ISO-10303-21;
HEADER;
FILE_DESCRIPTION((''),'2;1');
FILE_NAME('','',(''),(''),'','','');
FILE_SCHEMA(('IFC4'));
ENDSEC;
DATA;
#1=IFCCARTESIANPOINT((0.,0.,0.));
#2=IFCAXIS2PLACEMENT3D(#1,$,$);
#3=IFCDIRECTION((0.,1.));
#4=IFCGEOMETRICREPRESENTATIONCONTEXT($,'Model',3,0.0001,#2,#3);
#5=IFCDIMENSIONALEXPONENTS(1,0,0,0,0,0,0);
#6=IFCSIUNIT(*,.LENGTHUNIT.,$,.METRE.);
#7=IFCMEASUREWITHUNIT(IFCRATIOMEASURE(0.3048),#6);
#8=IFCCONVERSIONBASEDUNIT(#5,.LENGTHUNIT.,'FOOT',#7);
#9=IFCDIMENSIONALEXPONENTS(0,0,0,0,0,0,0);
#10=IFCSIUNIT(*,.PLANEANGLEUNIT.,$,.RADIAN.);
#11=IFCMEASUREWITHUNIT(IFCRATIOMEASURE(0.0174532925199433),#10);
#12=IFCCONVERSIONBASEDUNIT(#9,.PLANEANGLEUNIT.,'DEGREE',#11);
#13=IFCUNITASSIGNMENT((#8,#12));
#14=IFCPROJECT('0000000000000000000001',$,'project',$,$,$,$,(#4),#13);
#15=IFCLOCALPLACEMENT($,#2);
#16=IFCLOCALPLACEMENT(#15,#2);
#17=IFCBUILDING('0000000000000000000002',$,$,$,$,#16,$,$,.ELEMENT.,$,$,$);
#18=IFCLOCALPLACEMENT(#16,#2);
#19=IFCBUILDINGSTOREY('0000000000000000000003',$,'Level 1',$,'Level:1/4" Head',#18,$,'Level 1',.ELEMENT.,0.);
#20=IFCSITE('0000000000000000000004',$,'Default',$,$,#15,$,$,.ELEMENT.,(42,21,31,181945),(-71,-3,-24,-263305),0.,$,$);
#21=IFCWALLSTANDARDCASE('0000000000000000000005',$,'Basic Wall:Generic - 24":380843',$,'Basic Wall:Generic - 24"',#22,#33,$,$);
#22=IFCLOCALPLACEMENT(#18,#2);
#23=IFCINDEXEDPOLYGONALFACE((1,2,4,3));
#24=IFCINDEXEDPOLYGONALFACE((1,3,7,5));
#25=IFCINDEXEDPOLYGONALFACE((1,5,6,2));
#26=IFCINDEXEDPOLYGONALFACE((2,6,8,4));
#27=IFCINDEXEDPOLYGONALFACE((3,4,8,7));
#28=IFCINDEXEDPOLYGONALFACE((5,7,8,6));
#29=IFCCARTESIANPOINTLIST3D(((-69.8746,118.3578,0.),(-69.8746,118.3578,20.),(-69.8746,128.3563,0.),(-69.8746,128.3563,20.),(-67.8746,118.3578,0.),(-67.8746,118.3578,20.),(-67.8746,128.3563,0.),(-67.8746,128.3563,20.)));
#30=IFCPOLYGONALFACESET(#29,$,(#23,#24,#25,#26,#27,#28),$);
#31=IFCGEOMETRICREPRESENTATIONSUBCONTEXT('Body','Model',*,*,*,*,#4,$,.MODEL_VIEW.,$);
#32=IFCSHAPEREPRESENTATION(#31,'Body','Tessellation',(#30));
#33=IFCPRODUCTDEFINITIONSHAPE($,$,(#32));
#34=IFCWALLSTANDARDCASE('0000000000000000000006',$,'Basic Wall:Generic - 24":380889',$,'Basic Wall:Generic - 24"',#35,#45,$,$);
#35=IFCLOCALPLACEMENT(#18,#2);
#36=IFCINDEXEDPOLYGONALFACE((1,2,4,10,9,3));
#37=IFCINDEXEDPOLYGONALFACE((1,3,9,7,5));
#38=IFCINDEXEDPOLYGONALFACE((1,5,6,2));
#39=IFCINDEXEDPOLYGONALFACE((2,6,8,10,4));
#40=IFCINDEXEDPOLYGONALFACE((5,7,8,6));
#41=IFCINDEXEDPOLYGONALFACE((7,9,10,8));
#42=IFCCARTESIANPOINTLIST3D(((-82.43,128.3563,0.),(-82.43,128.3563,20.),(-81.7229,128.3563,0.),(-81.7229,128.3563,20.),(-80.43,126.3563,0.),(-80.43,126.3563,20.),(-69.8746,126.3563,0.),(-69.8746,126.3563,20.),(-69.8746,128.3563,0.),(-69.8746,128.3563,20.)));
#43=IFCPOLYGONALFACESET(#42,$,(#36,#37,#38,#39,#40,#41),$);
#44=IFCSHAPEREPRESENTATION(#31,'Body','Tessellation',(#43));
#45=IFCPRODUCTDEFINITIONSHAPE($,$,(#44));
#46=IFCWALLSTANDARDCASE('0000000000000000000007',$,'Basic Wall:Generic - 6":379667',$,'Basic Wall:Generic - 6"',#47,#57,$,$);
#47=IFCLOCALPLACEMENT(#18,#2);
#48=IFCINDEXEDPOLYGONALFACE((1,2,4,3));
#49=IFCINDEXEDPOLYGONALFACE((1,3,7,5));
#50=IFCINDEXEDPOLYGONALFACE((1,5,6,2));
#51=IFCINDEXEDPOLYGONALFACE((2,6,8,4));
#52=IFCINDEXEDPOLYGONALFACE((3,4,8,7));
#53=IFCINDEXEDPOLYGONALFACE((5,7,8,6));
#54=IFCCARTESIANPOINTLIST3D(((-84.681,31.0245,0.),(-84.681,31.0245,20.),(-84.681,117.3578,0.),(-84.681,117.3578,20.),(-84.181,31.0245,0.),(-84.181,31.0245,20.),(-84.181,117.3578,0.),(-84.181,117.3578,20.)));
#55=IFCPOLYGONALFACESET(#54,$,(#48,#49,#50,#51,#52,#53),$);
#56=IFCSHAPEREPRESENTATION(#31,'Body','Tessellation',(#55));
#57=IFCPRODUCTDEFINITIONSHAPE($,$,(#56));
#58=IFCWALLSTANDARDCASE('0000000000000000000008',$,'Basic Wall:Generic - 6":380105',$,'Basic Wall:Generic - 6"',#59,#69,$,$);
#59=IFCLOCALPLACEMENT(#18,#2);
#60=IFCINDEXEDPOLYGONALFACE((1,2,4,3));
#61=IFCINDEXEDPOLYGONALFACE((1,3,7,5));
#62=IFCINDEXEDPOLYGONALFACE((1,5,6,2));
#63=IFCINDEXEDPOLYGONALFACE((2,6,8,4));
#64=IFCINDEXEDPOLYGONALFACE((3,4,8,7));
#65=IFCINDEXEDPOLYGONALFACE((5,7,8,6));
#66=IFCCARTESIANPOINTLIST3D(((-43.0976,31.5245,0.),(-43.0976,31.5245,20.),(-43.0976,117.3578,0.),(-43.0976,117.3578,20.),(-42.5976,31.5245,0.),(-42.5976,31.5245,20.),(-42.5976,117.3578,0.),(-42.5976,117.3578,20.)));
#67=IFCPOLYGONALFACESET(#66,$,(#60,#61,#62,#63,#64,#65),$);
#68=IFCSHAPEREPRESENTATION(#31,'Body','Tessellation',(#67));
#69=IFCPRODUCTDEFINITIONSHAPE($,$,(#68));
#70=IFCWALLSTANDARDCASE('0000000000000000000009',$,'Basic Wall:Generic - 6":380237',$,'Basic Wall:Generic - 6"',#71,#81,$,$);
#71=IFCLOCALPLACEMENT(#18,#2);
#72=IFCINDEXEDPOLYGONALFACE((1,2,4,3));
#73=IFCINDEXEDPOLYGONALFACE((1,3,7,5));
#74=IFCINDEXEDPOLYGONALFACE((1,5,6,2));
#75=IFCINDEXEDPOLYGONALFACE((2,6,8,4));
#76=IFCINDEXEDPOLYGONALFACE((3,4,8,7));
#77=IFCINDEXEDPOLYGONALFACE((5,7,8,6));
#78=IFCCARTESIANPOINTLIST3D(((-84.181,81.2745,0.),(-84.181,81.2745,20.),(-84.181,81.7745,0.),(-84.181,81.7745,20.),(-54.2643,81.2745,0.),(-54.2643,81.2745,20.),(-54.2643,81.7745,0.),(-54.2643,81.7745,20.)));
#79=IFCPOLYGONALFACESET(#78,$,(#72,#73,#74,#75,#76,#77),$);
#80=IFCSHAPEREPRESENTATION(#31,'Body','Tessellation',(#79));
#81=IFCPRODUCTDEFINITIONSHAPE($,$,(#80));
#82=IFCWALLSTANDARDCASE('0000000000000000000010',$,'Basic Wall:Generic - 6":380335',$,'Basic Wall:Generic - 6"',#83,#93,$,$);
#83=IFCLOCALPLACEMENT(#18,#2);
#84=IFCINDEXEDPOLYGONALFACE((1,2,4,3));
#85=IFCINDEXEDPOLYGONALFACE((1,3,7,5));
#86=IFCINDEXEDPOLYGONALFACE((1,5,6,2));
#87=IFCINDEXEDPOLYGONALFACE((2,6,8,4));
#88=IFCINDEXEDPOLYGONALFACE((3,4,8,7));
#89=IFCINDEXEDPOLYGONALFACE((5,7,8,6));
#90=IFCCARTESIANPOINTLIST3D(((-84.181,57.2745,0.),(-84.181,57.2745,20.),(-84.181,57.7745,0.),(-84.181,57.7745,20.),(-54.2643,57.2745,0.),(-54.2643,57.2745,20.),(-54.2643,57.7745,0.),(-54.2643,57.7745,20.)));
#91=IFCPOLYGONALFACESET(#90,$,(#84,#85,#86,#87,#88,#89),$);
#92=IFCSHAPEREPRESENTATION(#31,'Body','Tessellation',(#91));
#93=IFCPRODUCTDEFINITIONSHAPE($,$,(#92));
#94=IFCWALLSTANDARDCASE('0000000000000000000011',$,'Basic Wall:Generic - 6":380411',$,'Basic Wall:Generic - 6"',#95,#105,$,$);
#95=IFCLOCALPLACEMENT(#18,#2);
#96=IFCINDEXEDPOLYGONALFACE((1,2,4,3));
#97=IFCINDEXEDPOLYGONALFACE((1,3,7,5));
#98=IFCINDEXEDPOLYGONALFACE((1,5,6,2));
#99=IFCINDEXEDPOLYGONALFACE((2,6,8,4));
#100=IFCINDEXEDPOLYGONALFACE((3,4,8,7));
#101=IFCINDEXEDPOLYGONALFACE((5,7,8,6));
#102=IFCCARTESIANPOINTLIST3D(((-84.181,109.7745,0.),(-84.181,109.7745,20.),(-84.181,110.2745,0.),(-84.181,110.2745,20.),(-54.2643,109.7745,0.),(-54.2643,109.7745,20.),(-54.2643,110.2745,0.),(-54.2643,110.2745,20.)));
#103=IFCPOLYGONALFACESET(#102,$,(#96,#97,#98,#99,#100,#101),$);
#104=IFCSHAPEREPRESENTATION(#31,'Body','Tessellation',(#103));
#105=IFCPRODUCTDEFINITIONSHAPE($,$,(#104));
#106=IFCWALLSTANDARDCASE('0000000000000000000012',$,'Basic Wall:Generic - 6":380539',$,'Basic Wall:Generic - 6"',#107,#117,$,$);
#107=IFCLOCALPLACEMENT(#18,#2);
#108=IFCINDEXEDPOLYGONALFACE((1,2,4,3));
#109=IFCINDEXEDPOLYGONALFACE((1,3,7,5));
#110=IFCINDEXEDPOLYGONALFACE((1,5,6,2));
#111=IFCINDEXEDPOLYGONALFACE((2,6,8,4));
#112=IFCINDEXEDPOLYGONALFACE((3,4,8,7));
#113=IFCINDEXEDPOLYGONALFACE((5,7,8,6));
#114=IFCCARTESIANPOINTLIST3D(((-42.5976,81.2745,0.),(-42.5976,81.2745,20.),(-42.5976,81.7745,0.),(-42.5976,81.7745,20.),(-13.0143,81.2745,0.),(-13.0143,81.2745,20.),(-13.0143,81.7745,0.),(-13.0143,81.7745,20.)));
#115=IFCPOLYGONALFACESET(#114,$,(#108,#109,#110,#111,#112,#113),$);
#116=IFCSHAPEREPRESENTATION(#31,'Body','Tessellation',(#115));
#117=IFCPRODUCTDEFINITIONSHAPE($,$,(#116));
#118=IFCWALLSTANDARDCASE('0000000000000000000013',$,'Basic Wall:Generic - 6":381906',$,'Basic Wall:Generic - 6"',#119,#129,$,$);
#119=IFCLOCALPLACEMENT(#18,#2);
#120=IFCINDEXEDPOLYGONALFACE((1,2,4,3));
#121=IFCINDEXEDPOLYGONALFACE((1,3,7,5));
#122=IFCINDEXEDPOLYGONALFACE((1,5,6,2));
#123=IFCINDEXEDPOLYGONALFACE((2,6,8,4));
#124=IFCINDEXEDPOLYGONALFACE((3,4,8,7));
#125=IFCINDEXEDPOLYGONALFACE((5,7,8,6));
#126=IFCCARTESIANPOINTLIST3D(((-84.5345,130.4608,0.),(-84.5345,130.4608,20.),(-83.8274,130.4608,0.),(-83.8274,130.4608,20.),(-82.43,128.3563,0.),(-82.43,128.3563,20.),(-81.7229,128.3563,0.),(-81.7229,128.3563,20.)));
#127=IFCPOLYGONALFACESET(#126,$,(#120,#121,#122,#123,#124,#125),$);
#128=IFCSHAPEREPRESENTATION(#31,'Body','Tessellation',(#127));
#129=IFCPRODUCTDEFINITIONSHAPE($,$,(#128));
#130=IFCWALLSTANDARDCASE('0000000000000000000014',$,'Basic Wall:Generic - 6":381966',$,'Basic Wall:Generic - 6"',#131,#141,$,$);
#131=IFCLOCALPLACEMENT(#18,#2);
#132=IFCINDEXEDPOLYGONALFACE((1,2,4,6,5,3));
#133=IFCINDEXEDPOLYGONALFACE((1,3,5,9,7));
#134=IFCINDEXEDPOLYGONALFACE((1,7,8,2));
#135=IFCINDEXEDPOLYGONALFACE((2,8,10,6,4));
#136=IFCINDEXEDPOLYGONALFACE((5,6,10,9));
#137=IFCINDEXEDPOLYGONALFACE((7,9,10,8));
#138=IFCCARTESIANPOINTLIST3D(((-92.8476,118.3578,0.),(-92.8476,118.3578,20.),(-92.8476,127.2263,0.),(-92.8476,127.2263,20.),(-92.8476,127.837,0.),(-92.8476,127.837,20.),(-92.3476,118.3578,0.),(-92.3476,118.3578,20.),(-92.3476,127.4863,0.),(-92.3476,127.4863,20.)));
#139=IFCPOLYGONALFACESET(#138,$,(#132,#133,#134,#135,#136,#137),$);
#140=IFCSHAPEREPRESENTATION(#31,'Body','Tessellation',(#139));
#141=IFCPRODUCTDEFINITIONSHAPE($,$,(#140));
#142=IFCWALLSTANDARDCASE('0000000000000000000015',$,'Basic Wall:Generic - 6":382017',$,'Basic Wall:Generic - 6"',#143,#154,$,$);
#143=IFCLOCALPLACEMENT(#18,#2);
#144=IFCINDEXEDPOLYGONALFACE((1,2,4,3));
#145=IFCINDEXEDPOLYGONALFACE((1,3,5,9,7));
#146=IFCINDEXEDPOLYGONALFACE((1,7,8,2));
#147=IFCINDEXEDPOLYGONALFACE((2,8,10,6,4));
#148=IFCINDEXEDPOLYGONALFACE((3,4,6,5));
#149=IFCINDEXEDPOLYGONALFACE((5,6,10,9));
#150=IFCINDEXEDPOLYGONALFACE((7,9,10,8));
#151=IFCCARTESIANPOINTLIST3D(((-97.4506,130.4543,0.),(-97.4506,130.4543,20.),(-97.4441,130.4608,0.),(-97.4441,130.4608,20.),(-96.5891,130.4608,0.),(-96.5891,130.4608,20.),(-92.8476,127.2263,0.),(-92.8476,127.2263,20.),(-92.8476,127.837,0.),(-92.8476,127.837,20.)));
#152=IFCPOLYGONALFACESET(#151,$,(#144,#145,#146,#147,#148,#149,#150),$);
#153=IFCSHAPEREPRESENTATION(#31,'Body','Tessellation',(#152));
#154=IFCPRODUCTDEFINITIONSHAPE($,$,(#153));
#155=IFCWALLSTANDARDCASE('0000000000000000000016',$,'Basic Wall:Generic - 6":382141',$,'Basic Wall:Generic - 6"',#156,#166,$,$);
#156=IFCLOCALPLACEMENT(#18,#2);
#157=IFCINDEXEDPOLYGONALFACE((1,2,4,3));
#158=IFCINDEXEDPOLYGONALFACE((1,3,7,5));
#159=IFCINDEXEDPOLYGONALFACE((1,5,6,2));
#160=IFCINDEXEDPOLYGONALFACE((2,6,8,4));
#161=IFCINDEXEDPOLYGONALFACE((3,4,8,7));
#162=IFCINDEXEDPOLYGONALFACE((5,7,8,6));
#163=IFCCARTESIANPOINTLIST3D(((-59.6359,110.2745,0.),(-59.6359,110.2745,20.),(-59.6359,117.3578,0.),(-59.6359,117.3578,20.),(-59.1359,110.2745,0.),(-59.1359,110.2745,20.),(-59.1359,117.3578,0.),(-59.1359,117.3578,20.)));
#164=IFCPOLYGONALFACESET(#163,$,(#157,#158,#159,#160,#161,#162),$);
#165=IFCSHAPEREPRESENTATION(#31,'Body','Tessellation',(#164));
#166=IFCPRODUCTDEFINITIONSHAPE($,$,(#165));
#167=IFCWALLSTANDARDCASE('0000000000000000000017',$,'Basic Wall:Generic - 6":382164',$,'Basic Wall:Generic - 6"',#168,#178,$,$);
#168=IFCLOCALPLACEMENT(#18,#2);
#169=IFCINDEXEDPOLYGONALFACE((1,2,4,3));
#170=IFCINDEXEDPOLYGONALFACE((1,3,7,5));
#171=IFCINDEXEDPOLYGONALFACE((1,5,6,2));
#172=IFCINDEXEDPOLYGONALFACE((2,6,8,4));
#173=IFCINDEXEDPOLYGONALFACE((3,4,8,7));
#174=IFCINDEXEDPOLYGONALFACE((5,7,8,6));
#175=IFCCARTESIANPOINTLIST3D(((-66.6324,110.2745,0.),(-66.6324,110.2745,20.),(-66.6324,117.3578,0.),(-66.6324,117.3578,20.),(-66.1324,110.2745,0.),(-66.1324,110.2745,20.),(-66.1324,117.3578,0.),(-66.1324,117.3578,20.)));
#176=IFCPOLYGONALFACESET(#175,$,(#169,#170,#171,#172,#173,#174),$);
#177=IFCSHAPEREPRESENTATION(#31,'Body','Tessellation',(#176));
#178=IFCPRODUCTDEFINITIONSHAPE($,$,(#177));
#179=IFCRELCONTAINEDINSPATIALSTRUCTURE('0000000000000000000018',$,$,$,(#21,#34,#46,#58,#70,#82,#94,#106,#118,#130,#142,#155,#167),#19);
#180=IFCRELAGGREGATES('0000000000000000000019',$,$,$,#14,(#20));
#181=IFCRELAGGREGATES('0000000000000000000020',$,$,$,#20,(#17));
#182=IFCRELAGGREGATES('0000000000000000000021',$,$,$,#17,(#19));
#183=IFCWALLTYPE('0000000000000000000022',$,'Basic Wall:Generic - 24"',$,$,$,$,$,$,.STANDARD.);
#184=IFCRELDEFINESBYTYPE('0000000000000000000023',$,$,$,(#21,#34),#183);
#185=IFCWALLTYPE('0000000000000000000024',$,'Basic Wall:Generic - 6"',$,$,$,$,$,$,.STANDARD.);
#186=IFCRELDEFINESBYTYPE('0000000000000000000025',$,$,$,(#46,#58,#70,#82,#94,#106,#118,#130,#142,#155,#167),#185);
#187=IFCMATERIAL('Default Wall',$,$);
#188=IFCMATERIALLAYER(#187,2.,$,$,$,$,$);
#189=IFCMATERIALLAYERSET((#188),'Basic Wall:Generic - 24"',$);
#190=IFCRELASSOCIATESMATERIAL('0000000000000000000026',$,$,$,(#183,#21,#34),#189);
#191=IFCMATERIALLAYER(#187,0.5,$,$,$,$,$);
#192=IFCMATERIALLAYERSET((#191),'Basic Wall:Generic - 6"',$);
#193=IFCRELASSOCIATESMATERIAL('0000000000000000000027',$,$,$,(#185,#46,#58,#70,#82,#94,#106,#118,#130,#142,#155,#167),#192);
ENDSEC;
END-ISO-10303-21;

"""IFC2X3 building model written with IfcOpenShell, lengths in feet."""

from ifc_helpers import new_model, entity, si_unit, converted_unit, direction, frame, frame_2d, origin, place, context, subcontext, project, spatial, polyline, rectangle, outline, extrude, material, layer, layer_set, layer_usage, type_object, element, save


model = new_model("IFC2X3")

# Units and contexts
model_context = context("Model", 3, precision=0.0001, world=origin(), true_north=direction((0.0, 1.0)))
body_context = subcontext(model_context, "Body", "Model", "MODEL_VIEW")
ifc_project = project(units=[converted_unit("LENGTHUNIT", "FOOT", entity("IfcRatioMeasure", 0.3048), si_unit("LENGTHUNIT", "METRE"), dimensions=[1, 0, 0, 0, 0, 0, 0]), converted_unit("PLANEANGLEUNIT", "DEGREE", entity("IfcRatioMeasure", 0.0174532925199433), si_unit("PLANEANGLEUNIT", "RADIAN"), dimensions=[0, 0, 0, 0, 0, 0, 0])], contexts=[model_context])

# Site, building, storey
site_placement = place(None, origin())
site = spatial("IfcSite", under=ifc_project, at=site_placement, Name="Default", CompositionType="ELEMENT", RefLatitude=(42, 21, 31, 181945), RefLongitude=(-71, -3, -24, -263305), RefElevation=0.0)
building_placement = place(site_placement, origin())
building = spatial("IfcBuilding", under=site, at=building_placement, CompositionType="ELEMENT")
storey_placement = place(building_placement, origin())
storey = spatial("IfcBuildingStorey", under=building, at=storey_placement, Name="Level 1", ObjectType="Level:1/4\" Head", LongName="Level 1", CompositionType="ELEMENT", Elevation=0.0)

# Walls
ifc_material = material(Name="Default Wall")
ifc_layer_1 = layer(ifc_material, 2.0)
ifc_layer_set_1 = layer_set([ifc_layer_1], Name="Basic Wall:Generic - 24\"")
ifc_layer_usage_1 = layer_usage(ifc_layer_set_1, "AXIS2", "NEGATIVE", 1.0)
wall_type_1 = type_object("IfcWallType", Name="Basic Wall:Generic - 24\"", PredefinedType="STANDARD", material=ifc_layer_set_1)
wall_1_placement = place(storey_placement, frame((-68.8746, 118.3578, 0.0), z_axis=(0.0, 0.0, 1.0), x_axis=(0.0, 1.0, 0.0)))
element("IfcWallStandardCase", 1, at=wall_1_placement, inside=storey, type_object=wall_type_1, material=ifc_layer_usage_1, Name="Basic Wall:Generic - 24\":380843", ObjectType="Basic Wall:Generic - 24\"", context=body_context, shape_type="SweptSolid", body=[
    extrude(rectangle(XDim=9.9985, YDim=2.0, at=frame_2d((4.9992, 0.0), x_axis=(-1.0, 0.0))), origin(), (0.0, 0.0, 1.0), 20.0),
])
ifc_layer_usage_2 = layer_usage(ifc_layer_set_1, "AXIS2", "NEGATIVE", 1.0)
wall_2_placement = place(storey_placement, frame((-69.8746, 127.3563, 0.0), z_axis=(0.0, 0.0, 1.0), x_axis=(-1.0, 0.0, 0.0)))
element("IfcWallStandardCase", 2, at=wall_2_placement, inside=storey, type_object=wall_type_1, material=ifc_layer_usage_2, Name="Basic Wall:Generic - 24\":380889", ObjectType="Basic Wall:Generic - 24\"", context=body_context, shape_type="SweptSolid", body=[
    extrude(outline(polyline([(12.5555, -1.0), (10.5555, 1.0), (0.0, 1.0), (0.0, -1.0), (11.8484, -1.0), (12.5555, -1.0)])), origin(), (0.0, 0.0, 1.0), 20.0),
])
ifc_layer_2 = layer(ifc_material, 0.5)
ifc_layer_set_2 = layer_set([ifc_layer_2], Name="Basic Wall:Generic - 6\"")
ifc_layer_usage_3 = layer_usage(ifc_layer_set_2, "AXIS2", "NEGATIVE", 0.25)
wall_type_2 = type_object("IfcWallType", Name="Basic Wall:Generic - 6\"", PredefinedType="STANDARD", material=ifc_layer_set_2)
wall_3_placement = place(storey_placement, frame((-84.431, 117.3578, 0.0), z_axis=(0.0, 0.0, 1.0), x_axis=(0.0, -1.0, 0.0)))
element("IfcWallStandardCase", 3, at=wall_3_placement, inside=storey, type_object=wall_type_2, material=ifc_layer_usage_3, Name="Basic Wall:Generic - 6\":379667", ObjectType="Basic Wall:Generic - 6\"", context=body_context, shape_type="SweptSolid", body=[
    extrude(rectangle(XDim=86.3333, YDim=0.5, at=frame_2d((43.1667, 0.0), x_axis=(-1.0, 0.0))), origin(), (0.0, 0.0, 1.0), 20.0),
])
ifc_layer_usage_4 = layer_usage(ifc_layer_set_2, "AXIS2", "NEGATIVE", 0.25)
wall_4_placement = place(storey_placement, frame((-42.8476, 117.3578, 0.0), z_axis=(0.0, 0.0, 1.0), x_axis=(0.0, -1.0, 0.0)))
element("IfcWallStandardCase", 4, at=wall_4_placement, inside=storey, type_object=wall_type_2, material=ifc_layer_usage_4, Name="Basic Wall:Generic - 6\":380105", ObjectType="Basic Wall:Generic - 6\"", context=body_context, shape_type="SweptSolid", body=[
    extrude(rectangle(XDim=85.8333, YDim=0.5, at=frame_2d((42.9167, 0.0), x_axis=(-1.0, 0.0))), origin(), (0.0, 0.0, 1.0), 20.0),
])
ifc_layer_usage_5 = layer_usage(ifc_layer_set_2, "AXIS2", "NEGATIVE", 0.25)
wall_5_placement = place(storey_placement, frame((-84.181, 81.5245, 0.0)))
element("IfcWallStandardCase", 5, at=wall_5_placement, inside=storey, type_object=wall_type_2, material=ifc_layer_usage_5, Name="Basic Wall:Generic - 6\":380237", ObjectType="Basic Wall:Generic - 6\"", context=body_context, shape_type="SweptSolid", body=[
    extrude(rectangle(XDim=29.9167, YDim=0.5, at=frame_2d((14.9583, 0.0), x_axis=(-1.0, 0.0))), origin(), (0.0, 0.0, 1.0), 20.0),
])
ifc_layer_usage_6 = layer_usage(ifc_layer_set_2, "AXIS2", "NEGATIVE", 0.25)
wall_6_placement = place(storey_placement, frame((-84.181, 57.5245, 0.0)))
element("IfcWallStandardCase", 6, at=wall_6_placement, inside=storey, type_object=wall_type_2, material=ifc_layer_usage_6, Name="Basic Wall:Generic - 6\":380335", ObjectType="Basic Wall:Generic - 6\"", context=body_context, shape_type="SweptSolid", body=[
    extrude(rectangle(XDim=29.9167, YDim=0.5, at=frame_2d((14.9583, 0.0), x_axis=(-1.0, 0.0))), origin(), (0.0, 0.0, 1.0), 20.0),
])
ifc_layer_usage_7 = layer_usage(ifc_layer_set_2, "AXIS2", "NEGATIVE", 0.25)
wall_7_placement = place(storey_placement, frame((-54.2643, 110.0245, 0.0), z_axis=(0.0, 0.0, 1.0), x_axis=(-1.0, 0.0, 0.0)))
element("IfcWallStandardCase", 7, at=wall_7_placement, inside=storey, type_object=wall_type_2, material=ifc_layer_usage_7, Name="Basic Wall:Generic - 6\":380411", ObjectType="Basic Wall:Generic - 6\"", context=body_context, shape_type="SweptSolid", body=[
    extrude(rectangle(XDim=29.9167, YDim=0.5, at=frame_2d((14.9583, 0.0), x_axis=(-1.0, 0.0))), origin(), (0.0, 0.0, 1.0), 20.0),
])
ifc_layer_usage_8 = layer_usage(ifc_layer_set_2, "AXIS2", "NEGATIVE", 0.25)
wall_8_placement = place(storey_placement, frame((-42.5976, 81.5245, 0.0)))
element("IfcWallStandardCase", 8, at=wall_8_placement, inside=storey, type_object=wall_type_2, material=ifc_layer_usage_8, Name="Basic Wall:Generic - 6\":380539", ObjectType="Basic Wall:Generic - 6\"", context=body_context, shape_type="SweptSolid", body=[
    extrude(rectangle(XDim=29.5833, YDim=0.5, at=frame_2d((14.7917, 0.0), x_axis=(-1.0, 0.0))), origin(), (0.0, 0.0, 1.0), 20.0),
])
ifc_layer_usage_9 = layer_usage(ifc_layer_set_2, "AXIS2", "NEGATIVE", 0.25)
wall_9_placement = place(storey_placement, frame((-84.3578, 130.6376, 0.0), z_axis=(0.0, 0.0, 1.0), x_axis=(0.707107, -0.707107, 0.0)))
element("IfcWallStandardCase", 9, at=wall_9_placement, inside=storey, type_object=wall_type_2, material=ifc_layer_usage_9, Name="Basic Wall:Generic - 6\":381906", ObjectType="Basic Wall:Generic - 6\"", context=body_context, shape_type="SweptSolid", body=[
    extrude(outline(polyline([(2.9762, -0.25), (3.4762, 0.25), (0.5, 0.25), (0.0, -0.25), (2.9762, -0.25)])), origin(), (0.0, 0.0, 1.0), 20.0),
])
ifc_layer_usage_10 = layer_usage(ifc_layer_set_2, "AXIS2", "NEGATIVE", 0.25)
wall_10_placement = place(storey_placement, frame((-92.5976, 118.3578, 0.0), z_axis=(0.0, 0.0, 1.0), x_axis=(0.0, 1.0, 0.0)))
element("IfcWallStandardCase", 10, at=wall_10_placement, inside=storey, type_object=wall_type_2, material=ifc_layer_usage_10, Name="Basic Wall:Generic - 6\":381966", ObjectType="Basic Wall:Generic - 6\"", context=body_context, shape_type="SweptSolid", body=[
    extrude(outline(polyline([(9.1285, -0.25), (9.4791, 0.25), (8.8684, 0.25), (0.0, 0.25), (0.0, -0.25), (9.1285, -0.25)])), origin(), (0.0, 0.0, 1.0), 20.0),
])
ifc_layer_usage_11 = layer_usage(ifc_layer_set_2, "AXIS2", "NEGATIVE", 0.25)
wall_11_placement = place(storey_placement, frame((-92.7041, 127.431, 0.0), z_axis=(0.0, 0.0, 1.0), x_axis=(-0.818735, 0.574172, 0.0)))
element("IfcWallStandardCase", 11, at=wall_11_placement, inside=storey, type_object=wall_type_2, material=ifc_layer_usage_11, Name="Basic Wall:Generic - 6\":382017", ObjectType="Basic Wall:Generic - 6\"", context=body_context, shape_type="SweptSolid", body=[
    extrude(outline(polyline([(4.9204, -0.25), (5.6204, 0.2409), (5.622, 0.25), (0.0, 0.25), (0.3506, -0.25), (4.9204, -0.25)])), origin(), (0.0, 0.0, 1.0), 20.0),
])
ifc_layer_usage_12 = layer_usage(ifc_layer_set_2, "AXIS2", "NEGATIVE", 0.25)
wall_12_placement = place(storey_placement, frame((-59.3859, 110.2745, 0.0), z_axis=(0.0, 0.0, 1.0), x_axis=(0.0, 1.0, 0.0)))
element("IfcWallStandardCase", 12, at=wall_12_placement, inside=storey, type_object=wall_type_2, material=ifc_layer_usage_12, Name="Basic Wall:Generic - 6\":382141", ObjectType="Basic Wall:Generic - 6\"", context=body_context, shape_type="SweptSolid", body=[
    extrude(rectangle(XDim=7.0833, YDim=0.5, at=frame_2d((3.5417, 0.0), x_axis=(-1.0, 0.0))), origin(), (0.0, 0.0, 1.0), 20.0),
])
ifc_layer_usage_13 = layer_usage(ifc_layer_set_2, "AXIS2", "NEGATIVE", 0.25)
wall_13_placement = place(storey_placement, frame((-66.3824, 110.2745, 0.0), z_axis=(0.0, 0.0, 1.0), x_axis=(0.0, 1.0, 0.0)))
element("IfcWallStandardCase", 13, at=wall_13_placement, inside=storey, type_object=wall_type_2, material=ifc_layer_usage_13, Name="Basic Wall:Generic - 6\":382164", ObjectType="Basic Wall:Generic - 6\"", context=body_context, shape_type="SweptSolid", body=[
    extrude(rectangle(XDim=7.0833, YDim=0.5, at=frame_2d((3.5417, 0.0), x_axis=(-1.0, 0.0))), origin(), (0.0, 0.0, 1.0), 20.0),
])

save(model, "model.ifc")
